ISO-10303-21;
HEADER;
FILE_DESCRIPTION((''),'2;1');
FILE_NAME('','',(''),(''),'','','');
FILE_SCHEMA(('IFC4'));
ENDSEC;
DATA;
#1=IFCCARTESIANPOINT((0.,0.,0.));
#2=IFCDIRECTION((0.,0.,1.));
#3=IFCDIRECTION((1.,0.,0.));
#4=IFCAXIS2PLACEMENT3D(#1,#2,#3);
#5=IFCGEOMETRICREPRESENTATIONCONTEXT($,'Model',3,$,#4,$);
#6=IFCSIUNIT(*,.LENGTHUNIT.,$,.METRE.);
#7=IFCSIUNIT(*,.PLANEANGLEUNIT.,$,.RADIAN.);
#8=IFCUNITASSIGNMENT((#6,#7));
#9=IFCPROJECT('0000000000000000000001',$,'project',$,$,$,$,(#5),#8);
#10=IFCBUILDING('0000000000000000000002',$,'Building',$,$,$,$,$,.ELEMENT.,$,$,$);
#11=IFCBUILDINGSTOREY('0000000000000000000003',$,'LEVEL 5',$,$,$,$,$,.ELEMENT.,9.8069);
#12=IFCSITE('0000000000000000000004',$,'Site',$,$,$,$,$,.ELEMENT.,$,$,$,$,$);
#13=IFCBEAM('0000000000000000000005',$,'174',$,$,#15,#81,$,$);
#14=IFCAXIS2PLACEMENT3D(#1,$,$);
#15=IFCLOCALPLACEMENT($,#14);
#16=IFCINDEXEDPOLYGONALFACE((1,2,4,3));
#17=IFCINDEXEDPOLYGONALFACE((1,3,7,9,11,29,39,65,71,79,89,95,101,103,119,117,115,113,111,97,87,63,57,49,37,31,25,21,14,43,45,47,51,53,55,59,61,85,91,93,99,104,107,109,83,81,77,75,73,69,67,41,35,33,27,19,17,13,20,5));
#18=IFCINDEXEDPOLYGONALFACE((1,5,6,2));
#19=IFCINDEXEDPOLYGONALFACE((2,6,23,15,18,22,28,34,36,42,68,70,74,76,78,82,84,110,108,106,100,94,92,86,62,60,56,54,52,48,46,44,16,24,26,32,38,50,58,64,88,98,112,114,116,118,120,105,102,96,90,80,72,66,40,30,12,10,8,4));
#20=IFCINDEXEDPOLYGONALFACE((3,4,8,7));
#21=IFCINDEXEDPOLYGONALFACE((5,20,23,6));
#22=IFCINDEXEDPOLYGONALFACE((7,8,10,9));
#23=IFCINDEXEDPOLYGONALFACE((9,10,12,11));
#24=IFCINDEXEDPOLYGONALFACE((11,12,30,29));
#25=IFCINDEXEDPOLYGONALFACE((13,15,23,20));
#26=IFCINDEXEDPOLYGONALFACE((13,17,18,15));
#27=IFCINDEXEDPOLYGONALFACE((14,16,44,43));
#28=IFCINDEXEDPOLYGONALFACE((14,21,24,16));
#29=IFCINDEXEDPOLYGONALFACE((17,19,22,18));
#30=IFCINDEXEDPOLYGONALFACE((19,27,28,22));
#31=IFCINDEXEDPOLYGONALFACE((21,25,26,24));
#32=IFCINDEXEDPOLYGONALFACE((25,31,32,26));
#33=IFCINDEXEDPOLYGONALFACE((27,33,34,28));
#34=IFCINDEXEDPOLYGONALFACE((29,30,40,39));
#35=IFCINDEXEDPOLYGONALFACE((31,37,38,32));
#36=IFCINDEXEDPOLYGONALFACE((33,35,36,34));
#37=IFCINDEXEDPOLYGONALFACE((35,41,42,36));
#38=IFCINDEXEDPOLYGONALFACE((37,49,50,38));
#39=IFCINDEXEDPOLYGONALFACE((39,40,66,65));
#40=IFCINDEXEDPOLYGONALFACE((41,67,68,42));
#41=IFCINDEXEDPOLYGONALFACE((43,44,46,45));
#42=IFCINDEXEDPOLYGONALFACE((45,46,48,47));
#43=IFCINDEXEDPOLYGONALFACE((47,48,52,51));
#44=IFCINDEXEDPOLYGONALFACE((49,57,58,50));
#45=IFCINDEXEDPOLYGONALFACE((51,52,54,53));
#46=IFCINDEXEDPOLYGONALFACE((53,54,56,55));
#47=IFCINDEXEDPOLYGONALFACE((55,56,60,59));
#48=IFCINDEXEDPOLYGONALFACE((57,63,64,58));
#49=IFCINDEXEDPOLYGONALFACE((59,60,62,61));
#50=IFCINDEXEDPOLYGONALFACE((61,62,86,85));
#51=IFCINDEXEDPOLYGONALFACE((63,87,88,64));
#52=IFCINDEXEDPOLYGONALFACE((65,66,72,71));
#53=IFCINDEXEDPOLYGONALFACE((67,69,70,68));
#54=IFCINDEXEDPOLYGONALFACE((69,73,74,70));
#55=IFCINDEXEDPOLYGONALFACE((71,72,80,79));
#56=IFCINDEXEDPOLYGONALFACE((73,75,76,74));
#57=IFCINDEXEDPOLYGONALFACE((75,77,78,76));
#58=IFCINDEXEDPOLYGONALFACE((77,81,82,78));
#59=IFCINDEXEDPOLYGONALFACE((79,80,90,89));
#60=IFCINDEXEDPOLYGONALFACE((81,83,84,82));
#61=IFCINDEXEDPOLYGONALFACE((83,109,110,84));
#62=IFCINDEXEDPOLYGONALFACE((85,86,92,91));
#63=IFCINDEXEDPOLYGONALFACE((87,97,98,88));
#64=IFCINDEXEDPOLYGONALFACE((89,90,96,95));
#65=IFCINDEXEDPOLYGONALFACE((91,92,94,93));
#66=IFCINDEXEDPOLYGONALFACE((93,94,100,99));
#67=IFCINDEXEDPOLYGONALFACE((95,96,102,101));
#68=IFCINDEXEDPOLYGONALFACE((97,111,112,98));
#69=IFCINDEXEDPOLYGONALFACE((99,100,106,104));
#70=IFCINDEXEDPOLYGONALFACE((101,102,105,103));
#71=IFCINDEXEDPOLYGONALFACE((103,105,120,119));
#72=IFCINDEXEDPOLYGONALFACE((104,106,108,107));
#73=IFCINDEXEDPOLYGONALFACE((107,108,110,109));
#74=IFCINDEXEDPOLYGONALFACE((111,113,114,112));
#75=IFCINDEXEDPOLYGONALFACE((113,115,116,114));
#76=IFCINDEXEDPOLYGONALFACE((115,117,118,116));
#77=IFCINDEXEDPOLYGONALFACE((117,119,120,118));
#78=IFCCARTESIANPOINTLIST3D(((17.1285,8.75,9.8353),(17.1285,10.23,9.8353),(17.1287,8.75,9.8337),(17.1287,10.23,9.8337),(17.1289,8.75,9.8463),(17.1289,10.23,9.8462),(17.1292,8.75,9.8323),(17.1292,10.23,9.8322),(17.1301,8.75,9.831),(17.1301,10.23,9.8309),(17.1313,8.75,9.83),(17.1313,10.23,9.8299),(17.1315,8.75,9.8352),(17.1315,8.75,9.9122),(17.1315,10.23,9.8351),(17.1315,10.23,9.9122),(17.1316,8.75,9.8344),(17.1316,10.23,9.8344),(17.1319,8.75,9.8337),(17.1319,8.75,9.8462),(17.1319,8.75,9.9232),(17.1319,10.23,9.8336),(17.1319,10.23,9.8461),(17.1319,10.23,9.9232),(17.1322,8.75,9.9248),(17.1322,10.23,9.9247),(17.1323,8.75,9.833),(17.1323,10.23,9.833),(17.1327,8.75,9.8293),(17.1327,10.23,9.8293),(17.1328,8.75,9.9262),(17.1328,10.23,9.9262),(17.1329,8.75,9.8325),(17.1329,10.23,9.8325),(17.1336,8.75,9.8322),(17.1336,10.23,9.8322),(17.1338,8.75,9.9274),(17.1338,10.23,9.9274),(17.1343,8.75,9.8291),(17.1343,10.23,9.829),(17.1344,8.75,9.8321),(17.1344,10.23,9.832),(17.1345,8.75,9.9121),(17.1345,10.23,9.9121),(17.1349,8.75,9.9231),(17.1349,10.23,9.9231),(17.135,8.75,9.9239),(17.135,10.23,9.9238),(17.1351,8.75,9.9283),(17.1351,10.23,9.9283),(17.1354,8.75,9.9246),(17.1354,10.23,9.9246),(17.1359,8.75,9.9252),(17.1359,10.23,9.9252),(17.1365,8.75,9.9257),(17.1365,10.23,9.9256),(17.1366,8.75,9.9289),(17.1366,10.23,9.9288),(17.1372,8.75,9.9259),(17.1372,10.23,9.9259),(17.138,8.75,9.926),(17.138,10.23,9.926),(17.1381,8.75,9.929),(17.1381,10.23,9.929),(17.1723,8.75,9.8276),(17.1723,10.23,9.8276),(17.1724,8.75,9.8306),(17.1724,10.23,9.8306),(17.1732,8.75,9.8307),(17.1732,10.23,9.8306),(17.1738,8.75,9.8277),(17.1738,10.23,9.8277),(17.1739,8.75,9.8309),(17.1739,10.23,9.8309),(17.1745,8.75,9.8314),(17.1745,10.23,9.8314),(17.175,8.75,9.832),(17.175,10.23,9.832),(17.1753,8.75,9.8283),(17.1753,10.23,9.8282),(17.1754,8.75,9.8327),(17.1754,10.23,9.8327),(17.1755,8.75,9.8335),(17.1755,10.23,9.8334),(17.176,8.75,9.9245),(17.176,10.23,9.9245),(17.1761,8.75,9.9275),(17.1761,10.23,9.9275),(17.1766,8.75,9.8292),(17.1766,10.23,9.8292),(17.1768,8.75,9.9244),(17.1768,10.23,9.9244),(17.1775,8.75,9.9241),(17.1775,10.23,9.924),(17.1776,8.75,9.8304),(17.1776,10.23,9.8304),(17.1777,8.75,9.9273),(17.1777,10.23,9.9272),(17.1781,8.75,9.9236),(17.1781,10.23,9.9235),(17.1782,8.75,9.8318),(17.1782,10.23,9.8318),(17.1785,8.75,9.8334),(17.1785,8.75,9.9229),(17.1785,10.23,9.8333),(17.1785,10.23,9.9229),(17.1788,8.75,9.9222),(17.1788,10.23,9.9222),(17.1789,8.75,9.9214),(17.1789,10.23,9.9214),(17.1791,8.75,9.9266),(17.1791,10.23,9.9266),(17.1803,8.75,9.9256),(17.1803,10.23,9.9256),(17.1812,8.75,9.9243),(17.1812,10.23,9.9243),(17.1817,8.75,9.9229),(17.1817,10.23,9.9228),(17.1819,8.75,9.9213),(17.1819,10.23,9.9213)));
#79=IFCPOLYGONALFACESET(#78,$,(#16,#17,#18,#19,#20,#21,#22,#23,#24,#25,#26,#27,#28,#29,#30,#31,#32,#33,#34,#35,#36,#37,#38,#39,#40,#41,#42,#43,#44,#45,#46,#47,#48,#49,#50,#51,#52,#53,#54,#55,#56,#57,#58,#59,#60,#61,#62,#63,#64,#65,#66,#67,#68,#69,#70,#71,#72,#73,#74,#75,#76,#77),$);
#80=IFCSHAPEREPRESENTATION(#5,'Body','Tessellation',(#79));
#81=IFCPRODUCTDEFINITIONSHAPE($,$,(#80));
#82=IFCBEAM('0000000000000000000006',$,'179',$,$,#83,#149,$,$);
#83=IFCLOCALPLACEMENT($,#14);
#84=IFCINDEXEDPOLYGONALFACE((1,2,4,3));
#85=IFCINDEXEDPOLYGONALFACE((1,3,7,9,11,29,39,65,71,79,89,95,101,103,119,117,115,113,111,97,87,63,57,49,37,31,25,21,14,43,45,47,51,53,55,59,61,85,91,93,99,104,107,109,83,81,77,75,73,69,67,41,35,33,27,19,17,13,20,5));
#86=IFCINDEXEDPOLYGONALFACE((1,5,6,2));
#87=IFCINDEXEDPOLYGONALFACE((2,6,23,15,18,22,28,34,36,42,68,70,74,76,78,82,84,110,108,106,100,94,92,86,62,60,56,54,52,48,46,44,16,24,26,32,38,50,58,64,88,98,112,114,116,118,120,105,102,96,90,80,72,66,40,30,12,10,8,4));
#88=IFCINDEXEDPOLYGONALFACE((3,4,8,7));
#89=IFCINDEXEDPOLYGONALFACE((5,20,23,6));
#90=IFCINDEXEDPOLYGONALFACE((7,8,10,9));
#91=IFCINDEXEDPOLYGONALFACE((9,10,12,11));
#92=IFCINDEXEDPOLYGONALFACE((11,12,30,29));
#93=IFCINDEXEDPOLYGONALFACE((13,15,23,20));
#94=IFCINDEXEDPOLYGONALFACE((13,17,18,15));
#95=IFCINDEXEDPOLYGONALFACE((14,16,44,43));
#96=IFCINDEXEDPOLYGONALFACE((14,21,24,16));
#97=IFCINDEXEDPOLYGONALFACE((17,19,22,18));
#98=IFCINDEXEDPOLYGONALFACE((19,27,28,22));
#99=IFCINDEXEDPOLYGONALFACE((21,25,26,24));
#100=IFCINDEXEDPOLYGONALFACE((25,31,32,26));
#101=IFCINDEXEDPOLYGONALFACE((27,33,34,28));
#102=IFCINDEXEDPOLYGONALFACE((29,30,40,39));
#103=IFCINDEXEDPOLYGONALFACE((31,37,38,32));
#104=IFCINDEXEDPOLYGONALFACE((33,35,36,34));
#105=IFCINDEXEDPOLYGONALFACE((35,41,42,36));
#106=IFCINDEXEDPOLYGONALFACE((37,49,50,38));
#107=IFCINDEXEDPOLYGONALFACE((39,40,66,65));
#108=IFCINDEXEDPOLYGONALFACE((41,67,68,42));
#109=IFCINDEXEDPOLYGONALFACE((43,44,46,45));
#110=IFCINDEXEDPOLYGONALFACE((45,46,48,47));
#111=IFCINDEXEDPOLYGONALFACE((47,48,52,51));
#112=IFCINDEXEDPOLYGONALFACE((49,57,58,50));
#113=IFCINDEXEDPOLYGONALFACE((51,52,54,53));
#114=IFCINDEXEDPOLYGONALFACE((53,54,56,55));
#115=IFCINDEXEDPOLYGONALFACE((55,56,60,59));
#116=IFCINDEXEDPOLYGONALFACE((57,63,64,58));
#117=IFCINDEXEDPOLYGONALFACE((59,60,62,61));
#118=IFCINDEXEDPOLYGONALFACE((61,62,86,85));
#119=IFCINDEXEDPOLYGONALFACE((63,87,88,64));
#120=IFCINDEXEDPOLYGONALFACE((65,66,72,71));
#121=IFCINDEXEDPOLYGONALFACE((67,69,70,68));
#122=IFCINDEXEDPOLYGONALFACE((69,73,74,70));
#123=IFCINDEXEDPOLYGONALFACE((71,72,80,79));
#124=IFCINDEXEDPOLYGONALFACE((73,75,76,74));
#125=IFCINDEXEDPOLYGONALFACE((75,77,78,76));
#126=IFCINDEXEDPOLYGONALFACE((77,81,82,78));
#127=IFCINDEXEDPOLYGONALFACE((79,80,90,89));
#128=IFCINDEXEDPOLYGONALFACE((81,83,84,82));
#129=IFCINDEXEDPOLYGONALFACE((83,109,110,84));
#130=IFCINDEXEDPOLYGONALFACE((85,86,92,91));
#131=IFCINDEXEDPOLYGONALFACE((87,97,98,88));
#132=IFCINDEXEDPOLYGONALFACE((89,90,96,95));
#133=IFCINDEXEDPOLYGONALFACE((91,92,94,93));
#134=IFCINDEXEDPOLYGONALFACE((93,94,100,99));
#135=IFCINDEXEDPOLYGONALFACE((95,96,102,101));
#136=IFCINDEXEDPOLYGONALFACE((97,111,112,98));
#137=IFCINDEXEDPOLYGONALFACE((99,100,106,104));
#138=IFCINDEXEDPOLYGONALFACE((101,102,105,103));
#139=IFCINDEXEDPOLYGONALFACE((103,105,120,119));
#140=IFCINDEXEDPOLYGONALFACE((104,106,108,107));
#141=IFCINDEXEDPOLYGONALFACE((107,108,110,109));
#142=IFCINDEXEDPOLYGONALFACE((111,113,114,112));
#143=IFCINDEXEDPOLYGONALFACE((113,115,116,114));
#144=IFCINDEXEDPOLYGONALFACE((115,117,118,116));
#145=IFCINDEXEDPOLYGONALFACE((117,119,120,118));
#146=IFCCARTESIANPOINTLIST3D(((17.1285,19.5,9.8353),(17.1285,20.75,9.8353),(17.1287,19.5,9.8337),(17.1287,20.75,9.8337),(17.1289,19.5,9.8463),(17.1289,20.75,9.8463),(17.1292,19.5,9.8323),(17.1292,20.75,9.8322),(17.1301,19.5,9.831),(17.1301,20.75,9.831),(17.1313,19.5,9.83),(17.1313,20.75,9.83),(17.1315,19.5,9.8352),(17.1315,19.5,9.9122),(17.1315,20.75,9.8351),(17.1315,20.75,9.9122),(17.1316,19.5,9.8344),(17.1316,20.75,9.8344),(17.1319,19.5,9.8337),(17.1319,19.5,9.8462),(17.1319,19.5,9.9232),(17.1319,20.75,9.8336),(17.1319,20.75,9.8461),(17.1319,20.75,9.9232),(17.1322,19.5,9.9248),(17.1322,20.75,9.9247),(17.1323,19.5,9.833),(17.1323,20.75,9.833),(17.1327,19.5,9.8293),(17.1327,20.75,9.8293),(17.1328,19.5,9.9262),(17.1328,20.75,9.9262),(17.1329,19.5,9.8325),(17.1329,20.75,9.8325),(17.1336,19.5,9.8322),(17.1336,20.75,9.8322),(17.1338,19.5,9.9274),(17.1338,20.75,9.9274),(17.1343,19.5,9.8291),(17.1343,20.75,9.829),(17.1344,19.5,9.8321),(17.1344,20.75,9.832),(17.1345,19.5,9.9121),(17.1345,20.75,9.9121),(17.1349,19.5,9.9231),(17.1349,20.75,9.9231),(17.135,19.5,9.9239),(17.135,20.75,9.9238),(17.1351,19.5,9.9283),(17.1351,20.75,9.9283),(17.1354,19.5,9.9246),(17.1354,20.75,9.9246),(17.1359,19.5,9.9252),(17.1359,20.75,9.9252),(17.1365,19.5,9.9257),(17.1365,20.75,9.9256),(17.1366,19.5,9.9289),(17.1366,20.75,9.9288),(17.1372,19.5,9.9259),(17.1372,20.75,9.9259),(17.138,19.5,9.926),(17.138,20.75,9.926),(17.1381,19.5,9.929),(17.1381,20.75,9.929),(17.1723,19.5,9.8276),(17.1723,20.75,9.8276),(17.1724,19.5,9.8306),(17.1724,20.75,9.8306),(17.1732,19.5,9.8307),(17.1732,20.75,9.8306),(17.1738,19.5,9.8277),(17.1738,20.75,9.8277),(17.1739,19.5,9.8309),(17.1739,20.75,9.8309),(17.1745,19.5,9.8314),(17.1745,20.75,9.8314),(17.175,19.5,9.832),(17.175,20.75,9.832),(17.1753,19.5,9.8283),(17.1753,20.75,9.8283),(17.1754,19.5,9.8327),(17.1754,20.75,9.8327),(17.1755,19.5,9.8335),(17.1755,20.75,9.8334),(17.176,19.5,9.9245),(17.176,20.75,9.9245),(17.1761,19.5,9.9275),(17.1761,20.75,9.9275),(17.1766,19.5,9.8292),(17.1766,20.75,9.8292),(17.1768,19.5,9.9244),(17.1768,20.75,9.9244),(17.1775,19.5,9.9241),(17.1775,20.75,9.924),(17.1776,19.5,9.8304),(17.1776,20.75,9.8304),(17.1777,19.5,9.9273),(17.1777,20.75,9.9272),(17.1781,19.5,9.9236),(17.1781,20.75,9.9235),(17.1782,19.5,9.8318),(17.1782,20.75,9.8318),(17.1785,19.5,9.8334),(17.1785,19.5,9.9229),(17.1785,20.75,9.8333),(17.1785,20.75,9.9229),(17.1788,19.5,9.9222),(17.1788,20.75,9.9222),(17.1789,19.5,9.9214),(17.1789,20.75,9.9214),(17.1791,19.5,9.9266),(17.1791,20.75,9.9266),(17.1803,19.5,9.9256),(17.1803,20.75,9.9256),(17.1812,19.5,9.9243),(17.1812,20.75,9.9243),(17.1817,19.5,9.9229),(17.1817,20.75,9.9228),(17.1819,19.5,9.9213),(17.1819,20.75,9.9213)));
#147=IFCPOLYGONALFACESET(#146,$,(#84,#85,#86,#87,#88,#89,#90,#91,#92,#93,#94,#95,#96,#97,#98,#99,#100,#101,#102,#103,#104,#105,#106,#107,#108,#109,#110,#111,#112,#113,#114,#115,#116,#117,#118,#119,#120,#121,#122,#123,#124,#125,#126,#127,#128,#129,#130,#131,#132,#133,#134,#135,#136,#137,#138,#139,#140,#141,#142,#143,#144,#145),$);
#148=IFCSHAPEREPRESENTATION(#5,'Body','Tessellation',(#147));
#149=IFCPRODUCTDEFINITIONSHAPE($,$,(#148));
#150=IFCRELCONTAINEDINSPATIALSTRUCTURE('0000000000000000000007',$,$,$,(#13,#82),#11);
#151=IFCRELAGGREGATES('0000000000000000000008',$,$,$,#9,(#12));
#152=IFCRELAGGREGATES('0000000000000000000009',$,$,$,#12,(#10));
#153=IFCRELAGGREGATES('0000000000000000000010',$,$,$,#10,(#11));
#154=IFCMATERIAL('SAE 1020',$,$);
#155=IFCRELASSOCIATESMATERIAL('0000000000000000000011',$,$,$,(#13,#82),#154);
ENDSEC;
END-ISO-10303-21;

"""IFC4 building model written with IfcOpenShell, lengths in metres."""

from ifc_helpers import new_model, si_unit, frame, origin_with_axes, origin_2d_with_axis, place, context, project, spatial, c_section, extrude, material, material_profile, profile_set, profile_usage, element, save


model = new_model("IFC4")

# Units and contexts
model_context = context("Model", 3, world=origin_with_axes())
ifc_project = project(units=[si_unit("LENGTHUNIT", "METRE"), si_unit("PLANEANGLEUNIT", "RADIAN")], contexts=[model_context])

# Site, building, storey
site = spatial("IfcSite", under=ifc_project, Name="Site", CompositionType="ELEMENT")
building = spatial("IfcBuilding", under=site, Name="Building", CompositionType="ELEMENT")
storey = spatial("IfcBuildingStorey", under=building, Name="LEVEL 5", CompositionType="ELEMENT", Elevation=9.8069)

# Beams
ifc_material = material(Name="SAE 1020")
ifc_material_profile_1 = material_profile(ifc_material, c_section(Depth=0.1, Width=0.05, WallThickness=0.003, Girth=0.017, InternalFilletRadius=0.003, at=origin_2d_with_axis()))
ifc_profile_set_1 = profile_set([ifc_material_profile_1])
ifc_profile_usage_1 = profile_usage(ifc_profile_set_1, cardinal=10)
beam_1_placement = place(None, frame((17.1552, 8.75, 9.8783), z_axis=(0.0, 1.0, -0.00003), x_axis=(-0.999256, 0.000001, 0.038562)))
element("IfcBeam", 1, at=beam_1_placement, inside=storey, material=ifc_profile_usage_1, Name="174", context=model_context, shape_type="SweptSolid", body=[
    extrude(c_section(Depth=0.1, Width=0.05, WallThickness=0.003, Girth=0.017, InternalFilletRadius=0.003, at=origin_2d_with_axis()), origin_with_axes(), (0.0, 0.0, 1.0), 1.48),
])
ifc_material_profile_2 = material_profile(ifc_material, c_section(Depth=0.1, Width=0.05, WallThickness=0.003, Girth=0.017, InternalFilletRadius=0.003, at=origin_2d_with_axis()))
ifc_profile_set_2 = profile_set([ifc_material_profile_2])
ifc_profile_usage_2 = profile_usage(ifc_profile_set_2, cardinal=10)
beam_2_placement = place(None, frame((17.1552, 19.5, 9.8783), z_axis=(0.0, 1.0, -0.00003), x_axis=(-0.999256, 0.000001, 0.038562)))
element("IfcBeam", 2, at=beam_2_placement, inside=storey, material=ifc_profile_usage_2, Name="179", context=model_context, shape_type="SweptSolid", body=[
    extrude(c_section(Depth=0.1, Width=0.05, WallThickness=0.003, Girth=0.017, InternalFilletRadius=0.003, at=origin_2d_with_axis()), origin_with_axes(), (0.0, 0.0, 1.0), 1.25),
])

save(model, "model.ifc")
